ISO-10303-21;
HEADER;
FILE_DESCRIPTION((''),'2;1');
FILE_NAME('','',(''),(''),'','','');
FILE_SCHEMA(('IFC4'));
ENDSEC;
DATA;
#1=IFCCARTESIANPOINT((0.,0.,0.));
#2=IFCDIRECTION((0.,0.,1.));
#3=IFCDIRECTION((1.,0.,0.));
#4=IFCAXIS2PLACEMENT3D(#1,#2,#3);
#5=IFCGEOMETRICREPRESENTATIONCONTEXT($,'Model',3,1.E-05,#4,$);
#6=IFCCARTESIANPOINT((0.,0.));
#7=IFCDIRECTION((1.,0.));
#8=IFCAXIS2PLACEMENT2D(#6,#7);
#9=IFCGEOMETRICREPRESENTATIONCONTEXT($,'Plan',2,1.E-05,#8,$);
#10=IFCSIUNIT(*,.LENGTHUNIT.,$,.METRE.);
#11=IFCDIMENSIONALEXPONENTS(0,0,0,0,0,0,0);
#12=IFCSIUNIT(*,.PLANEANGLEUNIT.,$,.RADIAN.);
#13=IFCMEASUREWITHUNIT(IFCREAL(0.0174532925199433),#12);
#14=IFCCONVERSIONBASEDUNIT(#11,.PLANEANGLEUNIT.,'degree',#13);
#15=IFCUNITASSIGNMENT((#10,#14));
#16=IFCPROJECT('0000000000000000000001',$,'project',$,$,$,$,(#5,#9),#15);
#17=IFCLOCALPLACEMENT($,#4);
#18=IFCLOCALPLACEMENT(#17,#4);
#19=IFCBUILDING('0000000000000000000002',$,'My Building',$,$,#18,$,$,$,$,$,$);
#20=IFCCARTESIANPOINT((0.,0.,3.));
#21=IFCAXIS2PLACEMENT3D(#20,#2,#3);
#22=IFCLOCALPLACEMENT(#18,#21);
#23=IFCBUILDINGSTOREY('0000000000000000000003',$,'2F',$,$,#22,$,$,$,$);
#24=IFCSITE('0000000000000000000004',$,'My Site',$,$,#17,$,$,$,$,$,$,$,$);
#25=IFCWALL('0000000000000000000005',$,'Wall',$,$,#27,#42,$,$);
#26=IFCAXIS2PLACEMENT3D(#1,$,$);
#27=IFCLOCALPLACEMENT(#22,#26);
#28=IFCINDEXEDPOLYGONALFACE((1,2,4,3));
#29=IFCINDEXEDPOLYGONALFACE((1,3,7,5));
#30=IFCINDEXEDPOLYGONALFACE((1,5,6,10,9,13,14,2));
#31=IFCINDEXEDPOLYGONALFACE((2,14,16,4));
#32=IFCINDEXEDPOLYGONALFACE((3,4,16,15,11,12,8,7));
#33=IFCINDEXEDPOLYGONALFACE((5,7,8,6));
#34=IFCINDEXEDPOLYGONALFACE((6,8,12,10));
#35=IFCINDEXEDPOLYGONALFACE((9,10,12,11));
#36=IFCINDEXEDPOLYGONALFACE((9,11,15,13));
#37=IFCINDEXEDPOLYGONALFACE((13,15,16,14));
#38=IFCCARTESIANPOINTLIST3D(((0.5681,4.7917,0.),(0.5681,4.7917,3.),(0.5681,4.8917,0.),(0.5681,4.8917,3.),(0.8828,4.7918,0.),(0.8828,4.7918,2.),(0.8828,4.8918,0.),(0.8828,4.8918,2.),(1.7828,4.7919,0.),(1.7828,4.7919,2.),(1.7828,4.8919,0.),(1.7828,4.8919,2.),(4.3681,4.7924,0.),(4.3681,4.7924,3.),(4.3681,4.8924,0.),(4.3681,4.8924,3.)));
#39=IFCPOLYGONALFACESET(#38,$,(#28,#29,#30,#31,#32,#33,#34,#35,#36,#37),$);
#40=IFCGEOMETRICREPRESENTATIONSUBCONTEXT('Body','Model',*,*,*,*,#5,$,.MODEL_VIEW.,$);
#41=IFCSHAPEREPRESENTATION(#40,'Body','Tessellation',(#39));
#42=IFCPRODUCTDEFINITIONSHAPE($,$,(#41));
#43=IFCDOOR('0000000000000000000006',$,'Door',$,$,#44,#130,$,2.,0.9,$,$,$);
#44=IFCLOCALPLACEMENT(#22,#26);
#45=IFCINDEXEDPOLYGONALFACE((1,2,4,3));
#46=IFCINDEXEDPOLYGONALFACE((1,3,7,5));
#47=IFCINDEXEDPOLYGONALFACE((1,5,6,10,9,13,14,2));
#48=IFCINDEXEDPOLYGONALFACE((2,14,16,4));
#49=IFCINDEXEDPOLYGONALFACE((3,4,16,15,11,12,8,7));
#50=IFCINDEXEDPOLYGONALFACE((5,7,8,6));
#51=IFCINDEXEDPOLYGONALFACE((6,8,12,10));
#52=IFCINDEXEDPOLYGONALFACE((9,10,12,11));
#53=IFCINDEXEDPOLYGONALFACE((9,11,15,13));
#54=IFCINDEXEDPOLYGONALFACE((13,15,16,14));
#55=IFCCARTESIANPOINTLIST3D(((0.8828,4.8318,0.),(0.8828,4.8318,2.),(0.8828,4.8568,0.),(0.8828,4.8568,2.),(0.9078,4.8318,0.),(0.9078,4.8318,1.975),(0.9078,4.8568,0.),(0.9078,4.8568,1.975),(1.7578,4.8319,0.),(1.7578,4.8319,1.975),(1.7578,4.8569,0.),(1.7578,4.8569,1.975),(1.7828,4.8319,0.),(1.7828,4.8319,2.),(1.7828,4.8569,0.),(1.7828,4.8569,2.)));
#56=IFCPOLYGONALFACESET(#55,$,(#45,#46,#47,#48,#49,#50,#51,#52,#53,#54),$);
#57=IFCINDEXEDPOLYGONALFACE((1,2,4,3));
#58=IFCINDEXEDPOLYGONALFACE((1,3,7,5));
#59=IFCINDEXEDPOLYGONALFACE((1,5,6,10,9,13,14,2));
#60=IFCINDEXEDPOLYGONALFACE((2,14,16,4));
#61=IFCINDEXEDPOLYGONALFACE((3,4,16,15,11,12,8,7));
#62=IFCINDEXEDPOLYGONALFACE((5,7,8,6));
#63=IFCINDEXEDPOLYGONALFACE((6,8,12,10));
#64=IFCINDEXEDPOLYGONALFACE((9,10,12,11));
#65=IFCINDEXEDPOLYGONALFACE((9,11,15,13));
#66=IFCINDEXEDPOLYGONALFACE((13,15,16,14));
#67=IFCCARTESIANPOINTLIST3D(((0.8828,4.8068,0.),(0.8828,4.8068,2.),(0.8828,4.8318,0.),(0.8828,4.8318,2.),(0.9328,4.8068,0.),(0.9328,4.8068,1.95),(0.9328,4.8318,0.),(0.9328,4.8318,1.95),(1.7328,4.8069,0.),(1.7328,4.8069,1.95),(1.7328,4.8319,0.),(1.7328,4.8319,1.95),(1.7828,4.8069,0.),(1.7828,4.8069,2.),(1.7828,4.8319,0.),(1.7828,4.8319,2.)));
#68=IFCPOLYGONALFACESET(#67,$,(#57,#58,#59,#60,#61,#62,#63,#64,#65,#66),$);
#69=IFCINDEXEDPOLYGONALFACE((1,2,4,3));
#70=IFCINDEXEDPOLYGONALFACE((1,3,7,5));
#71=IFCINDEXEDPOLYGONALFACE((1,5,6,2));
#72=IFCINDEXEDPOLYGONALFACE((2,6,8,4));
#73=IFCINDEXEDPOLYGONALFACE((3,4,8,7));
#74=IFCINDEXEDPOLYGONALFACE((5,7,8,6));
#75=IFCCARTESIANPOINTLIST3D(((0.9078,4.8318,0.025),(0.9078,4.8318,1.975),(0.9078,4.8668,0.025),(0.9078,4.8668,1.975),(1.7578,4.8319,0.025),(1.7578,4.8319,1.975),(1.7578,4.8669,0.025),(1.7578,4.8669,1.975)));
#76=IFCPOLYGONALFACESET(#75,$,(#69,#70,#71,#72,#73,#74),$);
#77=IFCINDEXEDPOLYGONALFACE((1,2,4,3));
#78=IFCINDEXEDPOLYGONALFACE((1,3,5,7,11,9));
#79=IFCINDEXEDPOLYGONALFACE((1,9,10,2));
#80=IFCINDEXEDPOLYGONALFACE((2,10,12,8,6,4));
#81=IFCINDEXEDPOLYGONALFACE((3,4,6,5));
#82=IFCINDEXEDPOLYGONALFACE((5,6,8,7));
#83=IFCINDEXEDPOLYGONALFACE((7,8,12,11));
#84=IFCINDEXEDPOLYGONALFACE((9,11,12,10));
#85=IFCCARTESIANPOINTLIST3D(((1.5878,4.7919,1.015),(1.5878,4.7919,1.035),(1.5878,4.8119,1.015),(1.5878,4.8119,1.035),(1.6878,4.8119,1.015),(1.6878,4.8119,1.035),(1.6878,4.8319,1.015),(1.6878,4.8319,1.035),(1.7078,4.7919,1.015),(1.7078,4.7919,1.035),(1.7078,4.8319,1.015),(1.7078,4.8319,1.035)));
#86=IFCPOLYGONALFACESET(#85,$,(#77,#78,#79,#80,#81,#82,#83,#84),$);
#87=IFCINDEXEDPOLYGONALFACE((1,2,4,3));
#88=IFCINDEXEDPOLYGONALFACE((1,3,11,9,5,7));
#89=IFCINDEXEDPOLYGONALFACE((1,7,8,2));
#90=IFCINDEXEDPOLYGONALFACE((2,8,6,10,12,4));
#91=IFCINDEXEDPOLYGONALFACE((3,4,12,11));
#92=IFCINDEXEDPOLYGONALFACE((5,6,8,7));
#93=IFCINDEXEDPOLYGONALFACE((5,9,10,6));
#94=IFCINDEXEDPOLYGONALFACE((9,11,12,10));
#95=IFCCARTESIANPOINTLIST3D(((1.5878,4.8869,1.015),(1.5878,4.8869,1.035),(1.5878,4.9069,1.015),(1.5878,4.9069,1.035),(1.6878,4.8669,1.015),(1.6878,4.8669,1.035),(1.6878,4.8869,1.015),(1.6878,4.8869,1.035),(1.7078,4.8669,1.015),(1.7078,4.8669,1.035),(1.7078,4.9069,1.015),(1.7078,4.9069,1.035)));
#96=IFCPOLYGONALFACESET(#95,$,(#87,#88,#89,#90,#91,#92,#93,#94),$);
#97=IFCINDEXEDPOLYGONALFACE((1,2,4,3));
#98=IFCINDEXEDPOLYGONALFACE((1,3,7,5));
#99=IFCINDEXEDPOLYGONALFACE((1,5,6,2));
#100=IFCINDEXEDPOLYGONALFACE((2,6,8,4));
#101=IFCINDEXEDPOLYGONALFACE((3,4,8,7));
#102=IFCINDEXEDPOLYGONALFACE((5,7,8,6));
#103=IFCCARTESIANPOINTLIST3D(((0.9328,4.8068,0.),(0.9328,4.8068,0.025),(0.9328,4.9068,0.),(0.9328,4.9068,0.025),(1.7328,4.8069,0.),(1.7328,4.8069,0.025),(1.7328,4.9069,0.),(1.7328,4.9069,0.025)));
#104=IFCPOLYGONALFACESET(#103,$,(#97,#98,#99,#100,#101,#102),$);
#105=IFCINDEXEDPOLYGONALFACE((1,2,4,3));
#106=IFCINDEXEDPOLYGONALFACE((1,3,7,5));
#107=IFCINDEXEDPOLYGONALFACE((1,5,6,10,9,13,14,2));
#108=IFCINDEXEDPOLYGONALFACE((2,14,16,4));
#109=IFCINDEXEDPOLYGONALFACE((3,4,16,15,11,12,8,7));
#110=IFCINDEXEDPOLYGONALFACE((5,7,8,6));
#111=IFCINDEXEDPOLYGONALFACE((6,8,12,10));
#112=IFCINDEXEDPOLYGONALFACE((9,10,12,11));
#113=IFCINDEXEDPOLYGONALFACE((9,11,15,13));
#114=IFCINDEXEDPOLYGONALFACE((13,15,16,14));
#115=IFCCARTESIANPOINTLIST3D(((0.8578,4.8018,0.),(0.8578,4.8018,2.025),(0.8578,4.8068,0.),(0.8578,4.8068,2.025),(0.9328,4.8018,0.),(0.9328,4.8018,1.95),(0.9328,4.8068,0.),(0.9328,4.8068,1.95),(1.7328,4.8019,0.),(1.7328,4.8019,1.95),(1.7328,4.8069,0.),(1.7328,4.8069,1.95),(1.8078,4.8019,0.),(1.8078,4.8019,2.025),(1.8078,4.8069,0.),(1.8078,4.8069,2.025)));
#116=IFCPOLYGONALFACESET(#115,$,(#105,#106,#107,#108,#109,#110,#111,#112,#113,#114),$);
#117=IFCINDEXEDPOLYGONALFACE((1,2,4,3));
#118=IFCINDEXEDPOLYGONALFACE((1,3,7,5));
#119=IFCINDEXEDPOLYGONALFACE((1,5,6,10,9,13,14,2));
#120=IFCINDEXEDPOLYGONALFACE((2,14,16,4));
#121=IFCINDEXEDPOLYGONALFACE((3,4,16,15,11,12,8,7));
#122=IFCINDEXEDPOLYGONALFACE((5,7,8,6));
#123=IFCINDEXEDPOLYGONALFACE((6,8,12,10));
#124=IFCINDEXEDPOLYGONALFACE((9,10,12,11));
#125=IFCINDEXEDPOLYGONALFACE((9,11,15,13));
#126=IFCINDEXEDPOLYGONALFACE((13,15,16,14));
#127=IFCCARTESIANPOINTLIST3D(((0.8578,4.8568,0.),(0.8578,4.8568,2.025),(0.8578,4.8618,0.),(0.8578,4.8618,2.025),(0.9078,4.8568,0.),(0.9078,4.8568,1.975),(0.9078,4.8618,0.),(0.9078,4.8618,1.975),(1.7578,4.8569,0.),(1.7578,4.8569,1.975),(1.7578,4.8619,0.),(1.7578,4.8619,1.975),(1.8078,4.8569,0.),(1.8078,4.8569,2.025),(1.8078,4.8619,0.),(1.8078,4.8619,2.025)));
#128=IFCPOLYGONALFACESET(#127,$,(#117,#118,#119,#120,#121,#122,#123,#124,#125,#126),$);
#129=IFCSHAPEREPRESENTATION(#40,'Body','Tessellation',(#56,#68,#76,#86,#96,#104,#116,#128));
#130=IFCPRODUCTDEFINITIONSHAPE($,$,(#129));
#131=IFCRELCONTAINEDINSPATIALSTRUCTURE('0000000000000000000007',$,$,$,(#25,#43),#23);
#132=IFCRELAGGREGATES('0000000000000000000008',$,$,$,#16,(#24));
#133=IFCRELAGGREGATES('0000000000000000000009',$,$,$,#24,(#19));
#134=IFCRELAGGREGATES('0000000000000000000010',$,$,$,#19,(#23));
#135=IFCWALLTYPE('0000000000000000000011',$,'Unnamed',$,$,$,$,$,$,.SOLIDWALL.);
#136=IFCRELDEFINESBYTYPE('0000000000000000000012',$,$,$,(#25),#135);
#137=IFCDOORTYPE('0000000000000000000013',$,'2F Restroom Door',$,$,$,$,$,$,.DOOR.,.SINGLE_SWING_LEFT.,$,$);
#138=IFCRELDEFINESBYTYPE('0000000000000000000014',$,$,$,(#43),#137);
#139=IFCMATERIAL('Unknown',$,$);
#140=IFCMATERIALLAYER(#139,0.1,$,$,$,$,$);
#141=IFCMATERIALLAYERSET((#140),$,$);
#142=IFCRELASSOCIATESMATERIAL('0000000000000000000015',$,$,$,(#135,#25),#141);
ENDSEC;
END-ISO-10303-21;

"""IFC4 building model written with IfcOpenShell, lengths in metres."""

from ifc_helpers import new_model, entity, si_unit, converted_unit, frame, origin_with_axes, origin_2d_with_axis, place, context, subcontext, project, spatial, line, indexed_curve, outline, extrude, shape, source, transform, mapped, material, layer, layer_set, layer_usage, type_object, type_shapes, element, fill, save


model = new_model("IFC4")

# Units and contexts
model_context = context("Model", 3, precision=1e-05, world=origin_with_axes())
plan_context = context("Plan", 2, precision=1e-05, world=origin_2d_with_axis())
body_context_1 = subcontext(model_context, "Body", "Model", "MODEL_VIEW")
body_context_2 = subcontext(plan_context, "Body", "Plan", "PLAN_VIEW")
ifc_project = project(units=[si_unit("LENGTHUNIT", "METRE"), converted_unit("PLANEANGLEUNIT", "degree", entity("IfcReal", 0.0174532925199433), si_unit("PLANEANGLEUNIT", "RADIAN"), dimensions=[0, 0, 0, 0, 0, 0, 0])], contexts=[model_context, plan_context])

# Site, building, storey
site_placement = place(None, origin_with_axes())
site = spatial("IfcSite", under=ifc_project, at=site_placement, Name="My Site")
building_placement = place(site_placement, origin_with_axes())
building = spatial("IfcBuilding", under=site, at=building_placement, Name="My Building")
storey_placement = place(building_placement, frame((0.0, 0.0, 3.0), z_axis=(0.0, 0.0, 1.0), x_axis=(1.0, 0.0, 0.0)))
storey = spatial("IfcBuildingStorey", under=building, at=storey_placement, Name="2F")

# Shared definitions
ifc_material = material(Name="Unknown")

# Shared definitions
ifc_layer_1 = layer(ifc_material, 0.1)
ifc_layer_set_1 = layer_set([ifc_layer_1])
wall_type = type_object("IfcWallType", Name="Unnamed", PredefinedType="SOLIDWALL", material=ifc_layer_set_1)

# Wall, opening, door
ifc_layer_usage_1 = layer_usage(ifc_layer_set_1, "AXIS2", "POSITIVE", 0.0)
wall_1_placement = place(storey_placement, frame((4.3681, 4.8924, 0.0), z_axis=(0.0, 0.0, 1.0), x_axis=(-1.0, -0.000193, 0.0)))
wall_1 = element("IfcWall", 1, at=wall_1_placement, inside=storey, type_object=wall_type, material=ifc_layer_usage_1, Name="Wall", context=body_context_1, shape_type="SweptSolid", body=[
    extrude(outline(indexed_curve([(0.0, 0.0), (0.0, 0.1), (3.8, 0.1), (3.8, 0.0)], segments=[line(1, 2, 3, 4, 1)])), origin_with_axes(), (0.0, 0.0, 1.0), 3.0),
])
shared_shape_1 = source(origin_with_axes(), body_context_1, "Body", "SweptSolid", [
    extrude(outline(indexed_curve([(0.0, 0.0), (0.9, 0.0), (0.9, 2.0), (0.0, 2.0)], segments=[line(1, 2, 3, 4, 1)])), frame((0.0, -0.6, 0.0), z_axis=(0.0, -1.0, 0.0), x_axis=(1.0, 0.0, 0.0)), (0.0, 0.0, -1.0), 1.2),
])
opening_1_placement = place(wall_1_placement, frame((2.5853, 0.0, 0.0), z_axis=(0.0, 0.0, 1.0), x_axis=(1.0, 0.0, 0.0)))
opening_1 = element("IfcOpeningElement", 2, at=opening_1_placement, cuts=wall_1, PredefinedType="OPENING", context=body_context_1, shape_type="MappedRepresentation", body=[
    mapped(shared_shape_1, transform((0.0, 0.0, 0.0), x_axis=(1.0, 0.0, 0.0), y_axis=(0.0, 1.0, 0.0), z_axis=(0.0, 0.0, 1.0), scale=1.0)),
])
door_type_1 = type_object("IfcDoorType", Name="2F Restroom Door", OperationType="SINGLE_SWING_LEFT", PredefinedType="DOOR")
shared_shape_2 = source(origin_with_axes(), body_context_1, "Body", "SweptSolid", [
    extrude(outline(indexed_curve([(0.0, 0.0), (0.0, 2.0), (0.9, 2.0), (0.9, 0.0), (0.875, 0.0), (0.875, 1.975), (0.025, 1.975), (0.025, 0.0)], segments=[line(1, 2, 3, 4, 5, 6, 7, 8, 1)])), frame((0.0, 0.025, 0.0), z_axis=(0.0, -1.0, 0.0), x_axis=(1.0, 0.0, 0.0)), (0.0, 0.0, -1.0), 0.025),
    extrude(outline(indexed_curve([(0.0, 0.0), (0.0, 2.0), (0.9, 2.0), (0.9, 0.0), (0.85, 0.0), (0.85, 1.95), (0.05, 1.95), (0.05, 0.0)], segments=[line(1, 2, 3, 4, 5, 6, 7, 8, 1)])), frame((0.0, 0.0, 0.0), z_axis=(0.0, -1.0, 0.0), x_axis=(1.0, 0.0, 0.0)), (0.0, 0.0, -1.0), 0.025),
    extrude(outline(indexed_curve([(0.0, 0.0), (0.85, 0.0), (0.85, 0.035), (0.0, 0.035)], segments=[line(1, 2, 3, 4, 1)])), frame((0.025, 0.025, 0.025), z_axis=(0.0, 0.0, 1.0), x_axis=(1.0, 0.0, 0.0)), (0.0, 0.0, 1.0), 1.95),
    extrude(outline(indexed_curve([(0.0, 0.0), (0.0, -0.04), (-0.12, -0.04), (-0.12, -0.02), (-0.02, -0.02), (-0.02, 0.0)], segments=[line(1, 2, 3, 4, 5, 6, 1)])), frame((0.825, 0.025, 1.015), z_axis=(0.0, 0.0, 1.0), x_axis=(1.0, 0.0, 0.0)), (0.0, 0.0, 1.0), 0.02),
    extrude(outline(indexed_curve([(0.0, 0.0), (0.0, 0.04), (-0.12, 0.04), (-0.12, 0.02), (-0.02, 0.02), (-0.02, 0.0)], segments=[line(1, 2, 3, 4, 5, 6, 1)])), frame((0.825, 0.06, 1.015), z_axis=(0.0, 0.0, 1.0), x_axis=(1.0, 0.0, 0.0)), (0.0, 0.0, 1.0), 0.02),
    extrude(outline(indexed_curve([(0.0, 0.0), (0.8, 0.0), (0.8, 0.1), (0.0, 0.1)], segments=[line(1, 2, 3, 4, 1)])), frame((0.05, 0.0, 0.0), z_axis=(0.0, 0.0, 1.0), x_axis=(1.0, 0.0, 0.0)), (0.0, 0.0, 1.0), 0.025),
    extrude(outline(indexed_curve([(0.0, 0.0), (0.0, 2.025), (0.95, 2.025), (0.95, 0.0), (0.875, 0.0), (0.875, 1.95), (0.075, 1.95), (0.075, 0.0)], segments=[line(1, 2, 3, 4, 5, 6, 7, 8, 1)])), frame((-0.025, -0.005, 0.0), z_axis=(0.0, -1.0, 0.0), x_axis=(1.0, 0.0, 0.0)), (0.0, 0.0, -1.0), 0.005),
    extrude(outline(indexed_curve([(0.0, 0.0), (0.0, 2.025), (0.95, 2.025), (0.95, 0.0), (0.9, 0.0), (0.9, 1.975), (0.05, 1.975), (0.05, 0.0)], segments=[line(1, 2, 3, 4, 5, 6, 7, 8, 1)])), frame((-0.025, 0.05, 0.0), z_axis=(0.0, -1.0, 0.0), x_axis=(1.0, 0.0, 0.0)), (0.0, 0.0, -1.0), 0.005),
])
shared_shape_3 = source(origin_with_axes(), body_context_2, "Body", "Curve2D", [
    entity("IfcIndexedPolyCurve", entity("IfcCartesianPointList2D", [[0.0, 0.0], [0.0, 0.05], [0.025, 0.05], [0.025, 0.025], [0.05, 0.025], [0.05, 0.0]]), [entity("IfcLineIndex", [1, 2, 3, 4, 5, 6, 1])]),
    entity("IfcIndexedPolyCurve", entity("IfcCartesianPointList2D", [[0.9, 0.0], [0.9, 0.05], [0.875, 0.05], [0.875, 0.025], [0.85, 0.025], [0.85, 0.0]]), [entity("IfcLineIndex", [1, 2, 3, 4, 5, 6, 1])]),
    entity("IfcTrimmedCurve", entity("IfcEllipse", entity("IfcAxis2Placement2D", entity("IfcCartesianPoint", [0.06, 0.05]), entity("IfcDirection", [1.0, 0.0])), 0.815, 0.85), [entity("IfcCartesianPoint", [0.875, 0.05])], [entity("IfcCartesianPoint", [0.06, 0.9])], True, "CARTESIAN"),
    entity("IfcIndexedPolyCurve", entity("IfcCartesianPointList2D", [[0.025, 0.05], [0.06, 0.05], [0.06, 0.9], [0.025, 0.9]]), [entity("IfcLineIndex", [1, 2, 3, 4, 1])]),
])
type_shapes(door_type_1, [shared_shape_2, shared_shape_3])
door_1_placement = place(opening_1_placement, frame((0.9, 0.085, 0.0), z_axis=(0.0, 0.0, 1.0), x_axis=(-1.0, 0.0, 0.0)))
door_1 = element("IfcDoor", 3, at=door_1_placement, inside=storey, type_object=door_type_1, Name="Door", OverallHeight=2.0, OverallWidth=0.9, shapes=[
    shape(body_context_1, "Body", "MappedRepresentation", [mapped(shared_shape_2, transform((0.0, 0.0, 0.0), x_axis=(1.0, 0.0, 0.0), y_axis=(0.0, 1.0, 0.0), z_axis=(0.0, 0.0, 1.0), scale=1.0))]),
    shape(body_context_2, "Body", "MappedRepresentation", [mapped(shared_shape_3, transform((0.0, 0.0, 0.0), x_axis=(1.0, 0.0, 0.0), y_axis=(0.0, 1.0, 0.0), z_axis=(0.0, 0.0, 1.0), scale=1.0))]),
])
fill(opening_1, door_1)

save(model, "model.ifc")
